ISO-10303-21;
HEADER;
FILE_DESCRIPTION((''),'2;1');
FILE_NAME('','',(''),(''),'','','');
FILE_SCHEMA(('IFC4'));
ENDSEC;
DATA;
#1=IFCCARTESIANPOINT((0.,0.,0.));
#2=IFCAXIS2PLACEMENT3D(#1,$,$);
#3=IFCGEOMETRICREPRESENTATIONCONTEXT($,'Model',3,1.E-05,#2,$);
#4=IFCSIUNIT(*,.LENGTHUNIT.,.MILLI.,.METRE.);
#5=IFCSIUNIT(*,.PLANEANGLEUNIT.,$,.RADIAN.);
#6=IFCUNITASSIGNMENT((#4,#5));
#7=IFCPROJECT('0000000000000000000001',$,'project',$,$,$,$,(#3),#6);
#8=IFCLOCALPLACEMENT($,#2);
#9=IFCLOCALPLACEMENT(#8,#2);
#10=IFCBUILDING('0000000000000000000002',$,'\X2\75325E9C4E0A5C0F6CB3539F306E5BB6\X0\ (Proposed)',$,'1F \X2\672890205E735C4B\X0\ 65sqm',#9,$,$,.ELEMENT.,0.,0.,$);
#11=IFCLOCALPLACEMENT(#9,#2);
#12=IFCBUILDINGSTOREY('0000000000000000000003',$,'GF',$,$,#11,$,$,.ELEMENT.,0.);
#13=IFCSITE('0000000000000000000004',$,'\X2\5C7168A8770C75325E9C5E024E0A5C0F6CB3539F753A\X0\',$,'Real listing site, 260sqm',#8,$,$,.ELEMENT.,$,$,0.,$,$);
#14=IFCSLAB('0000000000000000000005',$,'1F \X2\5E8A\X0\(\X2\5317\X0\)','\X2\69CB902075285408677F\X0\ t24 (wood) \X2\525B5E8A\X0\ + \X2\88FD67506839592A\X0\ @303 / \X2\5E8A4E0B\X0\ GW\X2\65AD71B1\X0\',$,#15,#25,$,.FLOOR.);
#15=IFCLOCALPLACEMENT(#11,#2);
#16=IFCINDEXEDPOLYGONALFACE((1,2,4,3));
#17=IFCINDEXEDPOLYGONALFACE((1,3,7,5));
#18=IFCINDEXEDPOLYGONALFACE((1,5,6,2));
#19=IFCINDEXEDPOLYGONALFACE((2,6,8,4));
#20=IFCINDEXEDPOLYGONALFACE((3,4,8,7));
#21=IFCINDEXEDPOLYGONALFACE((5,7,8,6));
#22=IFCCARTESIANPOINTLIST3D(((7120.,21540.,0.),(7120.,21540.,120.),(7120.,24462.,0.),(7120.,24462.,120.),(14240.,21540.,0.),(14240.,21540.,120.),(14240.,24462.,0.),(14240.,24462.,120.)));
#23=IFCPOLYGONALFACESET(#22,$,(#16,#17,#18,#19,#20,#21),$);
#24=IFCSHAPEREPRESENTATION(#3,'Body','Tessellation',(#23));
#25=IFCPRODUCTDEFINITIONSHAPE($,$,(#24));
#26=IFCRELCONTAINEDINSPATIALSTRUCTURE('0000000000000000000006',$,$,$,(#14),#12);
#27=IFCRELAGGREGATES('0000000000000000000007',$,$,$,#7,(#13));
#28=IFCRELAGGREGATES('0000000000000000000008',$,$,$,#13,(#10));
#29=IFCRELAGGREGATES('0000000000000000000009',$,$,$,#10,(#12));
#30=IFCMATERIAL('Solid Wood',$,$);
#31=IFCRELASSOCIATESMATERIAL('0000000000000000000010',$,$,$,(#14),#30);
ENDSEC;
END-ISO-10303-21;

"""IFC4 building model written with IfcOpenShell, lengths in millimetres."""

from ifc_helpers import new_model, si_unit, frame, frame_2d, origin, place, context, project, spatial, rectangle, extrude, material, element, save


model = new_model("IFC4")

# Units and contexts
model_context = context("Model", 3, precision=1e-05, world=origin())
ifc_project = project(units=[si_unit("LENGTHUNIT", "METRE", prefix="MILLI"), si_unit("PLANEANGLEUNIT", "RADIAN")], contexts=[model_context])

# Site, building, storey
site_placement = place(None, origin())
site = spatial("IfcSite", under=ifc_project, at=site_placement, Name="山梨県甲府市上小河原町", ObjectType="Real listing site, 260sqm", CompositionType="ELEMENT", RefElevation=0.0)
building_placement = place(site_placement, origin())
building = spatial("IfcBuilding", under=site, at=building_placement, Name="甲府上小河原の家 (Proposed)", ObjectType="1F 木造平屋 65sqm", CompositionType="ELEMENT", ElevationOfRefHeight=0.0, ElevationOfTerrain=0.0)
storey_placement = place(building_placement, origin())
storey = spatial("IfcBuildingStorey", under=building, at=storey_placement, Name="GF", CompositionType="ELEMENT", Elevation=0.0)

# Shared definitions
ifc_material_1 = material(Name="Solid Wood")

# Slab
slab_1_placement = place(storey_placement, frame((3560.0, 10770.0, 0.0)))
element("IfcSlab", 1, at=slab_1_placement, inside=storey, material=ifc_material_1, Name="1F 床(北)", Description="構造用合板 t24 (wood) 剛床 + 製材根太 @303 / 床下 GW断熱", PredefinedType="FLOOR", context=model_context, shape_type="SweptSolid", body=[
    extrude(rectangle(XDim=7120.0, YDim=2922.0, at=frame_2d((3560.0, 1461.0))), frame((3560.0, 10770.0, 0.0)), (0.0, 0.0, 1.0), 120.0),
])

save(model, "model.ifc")
